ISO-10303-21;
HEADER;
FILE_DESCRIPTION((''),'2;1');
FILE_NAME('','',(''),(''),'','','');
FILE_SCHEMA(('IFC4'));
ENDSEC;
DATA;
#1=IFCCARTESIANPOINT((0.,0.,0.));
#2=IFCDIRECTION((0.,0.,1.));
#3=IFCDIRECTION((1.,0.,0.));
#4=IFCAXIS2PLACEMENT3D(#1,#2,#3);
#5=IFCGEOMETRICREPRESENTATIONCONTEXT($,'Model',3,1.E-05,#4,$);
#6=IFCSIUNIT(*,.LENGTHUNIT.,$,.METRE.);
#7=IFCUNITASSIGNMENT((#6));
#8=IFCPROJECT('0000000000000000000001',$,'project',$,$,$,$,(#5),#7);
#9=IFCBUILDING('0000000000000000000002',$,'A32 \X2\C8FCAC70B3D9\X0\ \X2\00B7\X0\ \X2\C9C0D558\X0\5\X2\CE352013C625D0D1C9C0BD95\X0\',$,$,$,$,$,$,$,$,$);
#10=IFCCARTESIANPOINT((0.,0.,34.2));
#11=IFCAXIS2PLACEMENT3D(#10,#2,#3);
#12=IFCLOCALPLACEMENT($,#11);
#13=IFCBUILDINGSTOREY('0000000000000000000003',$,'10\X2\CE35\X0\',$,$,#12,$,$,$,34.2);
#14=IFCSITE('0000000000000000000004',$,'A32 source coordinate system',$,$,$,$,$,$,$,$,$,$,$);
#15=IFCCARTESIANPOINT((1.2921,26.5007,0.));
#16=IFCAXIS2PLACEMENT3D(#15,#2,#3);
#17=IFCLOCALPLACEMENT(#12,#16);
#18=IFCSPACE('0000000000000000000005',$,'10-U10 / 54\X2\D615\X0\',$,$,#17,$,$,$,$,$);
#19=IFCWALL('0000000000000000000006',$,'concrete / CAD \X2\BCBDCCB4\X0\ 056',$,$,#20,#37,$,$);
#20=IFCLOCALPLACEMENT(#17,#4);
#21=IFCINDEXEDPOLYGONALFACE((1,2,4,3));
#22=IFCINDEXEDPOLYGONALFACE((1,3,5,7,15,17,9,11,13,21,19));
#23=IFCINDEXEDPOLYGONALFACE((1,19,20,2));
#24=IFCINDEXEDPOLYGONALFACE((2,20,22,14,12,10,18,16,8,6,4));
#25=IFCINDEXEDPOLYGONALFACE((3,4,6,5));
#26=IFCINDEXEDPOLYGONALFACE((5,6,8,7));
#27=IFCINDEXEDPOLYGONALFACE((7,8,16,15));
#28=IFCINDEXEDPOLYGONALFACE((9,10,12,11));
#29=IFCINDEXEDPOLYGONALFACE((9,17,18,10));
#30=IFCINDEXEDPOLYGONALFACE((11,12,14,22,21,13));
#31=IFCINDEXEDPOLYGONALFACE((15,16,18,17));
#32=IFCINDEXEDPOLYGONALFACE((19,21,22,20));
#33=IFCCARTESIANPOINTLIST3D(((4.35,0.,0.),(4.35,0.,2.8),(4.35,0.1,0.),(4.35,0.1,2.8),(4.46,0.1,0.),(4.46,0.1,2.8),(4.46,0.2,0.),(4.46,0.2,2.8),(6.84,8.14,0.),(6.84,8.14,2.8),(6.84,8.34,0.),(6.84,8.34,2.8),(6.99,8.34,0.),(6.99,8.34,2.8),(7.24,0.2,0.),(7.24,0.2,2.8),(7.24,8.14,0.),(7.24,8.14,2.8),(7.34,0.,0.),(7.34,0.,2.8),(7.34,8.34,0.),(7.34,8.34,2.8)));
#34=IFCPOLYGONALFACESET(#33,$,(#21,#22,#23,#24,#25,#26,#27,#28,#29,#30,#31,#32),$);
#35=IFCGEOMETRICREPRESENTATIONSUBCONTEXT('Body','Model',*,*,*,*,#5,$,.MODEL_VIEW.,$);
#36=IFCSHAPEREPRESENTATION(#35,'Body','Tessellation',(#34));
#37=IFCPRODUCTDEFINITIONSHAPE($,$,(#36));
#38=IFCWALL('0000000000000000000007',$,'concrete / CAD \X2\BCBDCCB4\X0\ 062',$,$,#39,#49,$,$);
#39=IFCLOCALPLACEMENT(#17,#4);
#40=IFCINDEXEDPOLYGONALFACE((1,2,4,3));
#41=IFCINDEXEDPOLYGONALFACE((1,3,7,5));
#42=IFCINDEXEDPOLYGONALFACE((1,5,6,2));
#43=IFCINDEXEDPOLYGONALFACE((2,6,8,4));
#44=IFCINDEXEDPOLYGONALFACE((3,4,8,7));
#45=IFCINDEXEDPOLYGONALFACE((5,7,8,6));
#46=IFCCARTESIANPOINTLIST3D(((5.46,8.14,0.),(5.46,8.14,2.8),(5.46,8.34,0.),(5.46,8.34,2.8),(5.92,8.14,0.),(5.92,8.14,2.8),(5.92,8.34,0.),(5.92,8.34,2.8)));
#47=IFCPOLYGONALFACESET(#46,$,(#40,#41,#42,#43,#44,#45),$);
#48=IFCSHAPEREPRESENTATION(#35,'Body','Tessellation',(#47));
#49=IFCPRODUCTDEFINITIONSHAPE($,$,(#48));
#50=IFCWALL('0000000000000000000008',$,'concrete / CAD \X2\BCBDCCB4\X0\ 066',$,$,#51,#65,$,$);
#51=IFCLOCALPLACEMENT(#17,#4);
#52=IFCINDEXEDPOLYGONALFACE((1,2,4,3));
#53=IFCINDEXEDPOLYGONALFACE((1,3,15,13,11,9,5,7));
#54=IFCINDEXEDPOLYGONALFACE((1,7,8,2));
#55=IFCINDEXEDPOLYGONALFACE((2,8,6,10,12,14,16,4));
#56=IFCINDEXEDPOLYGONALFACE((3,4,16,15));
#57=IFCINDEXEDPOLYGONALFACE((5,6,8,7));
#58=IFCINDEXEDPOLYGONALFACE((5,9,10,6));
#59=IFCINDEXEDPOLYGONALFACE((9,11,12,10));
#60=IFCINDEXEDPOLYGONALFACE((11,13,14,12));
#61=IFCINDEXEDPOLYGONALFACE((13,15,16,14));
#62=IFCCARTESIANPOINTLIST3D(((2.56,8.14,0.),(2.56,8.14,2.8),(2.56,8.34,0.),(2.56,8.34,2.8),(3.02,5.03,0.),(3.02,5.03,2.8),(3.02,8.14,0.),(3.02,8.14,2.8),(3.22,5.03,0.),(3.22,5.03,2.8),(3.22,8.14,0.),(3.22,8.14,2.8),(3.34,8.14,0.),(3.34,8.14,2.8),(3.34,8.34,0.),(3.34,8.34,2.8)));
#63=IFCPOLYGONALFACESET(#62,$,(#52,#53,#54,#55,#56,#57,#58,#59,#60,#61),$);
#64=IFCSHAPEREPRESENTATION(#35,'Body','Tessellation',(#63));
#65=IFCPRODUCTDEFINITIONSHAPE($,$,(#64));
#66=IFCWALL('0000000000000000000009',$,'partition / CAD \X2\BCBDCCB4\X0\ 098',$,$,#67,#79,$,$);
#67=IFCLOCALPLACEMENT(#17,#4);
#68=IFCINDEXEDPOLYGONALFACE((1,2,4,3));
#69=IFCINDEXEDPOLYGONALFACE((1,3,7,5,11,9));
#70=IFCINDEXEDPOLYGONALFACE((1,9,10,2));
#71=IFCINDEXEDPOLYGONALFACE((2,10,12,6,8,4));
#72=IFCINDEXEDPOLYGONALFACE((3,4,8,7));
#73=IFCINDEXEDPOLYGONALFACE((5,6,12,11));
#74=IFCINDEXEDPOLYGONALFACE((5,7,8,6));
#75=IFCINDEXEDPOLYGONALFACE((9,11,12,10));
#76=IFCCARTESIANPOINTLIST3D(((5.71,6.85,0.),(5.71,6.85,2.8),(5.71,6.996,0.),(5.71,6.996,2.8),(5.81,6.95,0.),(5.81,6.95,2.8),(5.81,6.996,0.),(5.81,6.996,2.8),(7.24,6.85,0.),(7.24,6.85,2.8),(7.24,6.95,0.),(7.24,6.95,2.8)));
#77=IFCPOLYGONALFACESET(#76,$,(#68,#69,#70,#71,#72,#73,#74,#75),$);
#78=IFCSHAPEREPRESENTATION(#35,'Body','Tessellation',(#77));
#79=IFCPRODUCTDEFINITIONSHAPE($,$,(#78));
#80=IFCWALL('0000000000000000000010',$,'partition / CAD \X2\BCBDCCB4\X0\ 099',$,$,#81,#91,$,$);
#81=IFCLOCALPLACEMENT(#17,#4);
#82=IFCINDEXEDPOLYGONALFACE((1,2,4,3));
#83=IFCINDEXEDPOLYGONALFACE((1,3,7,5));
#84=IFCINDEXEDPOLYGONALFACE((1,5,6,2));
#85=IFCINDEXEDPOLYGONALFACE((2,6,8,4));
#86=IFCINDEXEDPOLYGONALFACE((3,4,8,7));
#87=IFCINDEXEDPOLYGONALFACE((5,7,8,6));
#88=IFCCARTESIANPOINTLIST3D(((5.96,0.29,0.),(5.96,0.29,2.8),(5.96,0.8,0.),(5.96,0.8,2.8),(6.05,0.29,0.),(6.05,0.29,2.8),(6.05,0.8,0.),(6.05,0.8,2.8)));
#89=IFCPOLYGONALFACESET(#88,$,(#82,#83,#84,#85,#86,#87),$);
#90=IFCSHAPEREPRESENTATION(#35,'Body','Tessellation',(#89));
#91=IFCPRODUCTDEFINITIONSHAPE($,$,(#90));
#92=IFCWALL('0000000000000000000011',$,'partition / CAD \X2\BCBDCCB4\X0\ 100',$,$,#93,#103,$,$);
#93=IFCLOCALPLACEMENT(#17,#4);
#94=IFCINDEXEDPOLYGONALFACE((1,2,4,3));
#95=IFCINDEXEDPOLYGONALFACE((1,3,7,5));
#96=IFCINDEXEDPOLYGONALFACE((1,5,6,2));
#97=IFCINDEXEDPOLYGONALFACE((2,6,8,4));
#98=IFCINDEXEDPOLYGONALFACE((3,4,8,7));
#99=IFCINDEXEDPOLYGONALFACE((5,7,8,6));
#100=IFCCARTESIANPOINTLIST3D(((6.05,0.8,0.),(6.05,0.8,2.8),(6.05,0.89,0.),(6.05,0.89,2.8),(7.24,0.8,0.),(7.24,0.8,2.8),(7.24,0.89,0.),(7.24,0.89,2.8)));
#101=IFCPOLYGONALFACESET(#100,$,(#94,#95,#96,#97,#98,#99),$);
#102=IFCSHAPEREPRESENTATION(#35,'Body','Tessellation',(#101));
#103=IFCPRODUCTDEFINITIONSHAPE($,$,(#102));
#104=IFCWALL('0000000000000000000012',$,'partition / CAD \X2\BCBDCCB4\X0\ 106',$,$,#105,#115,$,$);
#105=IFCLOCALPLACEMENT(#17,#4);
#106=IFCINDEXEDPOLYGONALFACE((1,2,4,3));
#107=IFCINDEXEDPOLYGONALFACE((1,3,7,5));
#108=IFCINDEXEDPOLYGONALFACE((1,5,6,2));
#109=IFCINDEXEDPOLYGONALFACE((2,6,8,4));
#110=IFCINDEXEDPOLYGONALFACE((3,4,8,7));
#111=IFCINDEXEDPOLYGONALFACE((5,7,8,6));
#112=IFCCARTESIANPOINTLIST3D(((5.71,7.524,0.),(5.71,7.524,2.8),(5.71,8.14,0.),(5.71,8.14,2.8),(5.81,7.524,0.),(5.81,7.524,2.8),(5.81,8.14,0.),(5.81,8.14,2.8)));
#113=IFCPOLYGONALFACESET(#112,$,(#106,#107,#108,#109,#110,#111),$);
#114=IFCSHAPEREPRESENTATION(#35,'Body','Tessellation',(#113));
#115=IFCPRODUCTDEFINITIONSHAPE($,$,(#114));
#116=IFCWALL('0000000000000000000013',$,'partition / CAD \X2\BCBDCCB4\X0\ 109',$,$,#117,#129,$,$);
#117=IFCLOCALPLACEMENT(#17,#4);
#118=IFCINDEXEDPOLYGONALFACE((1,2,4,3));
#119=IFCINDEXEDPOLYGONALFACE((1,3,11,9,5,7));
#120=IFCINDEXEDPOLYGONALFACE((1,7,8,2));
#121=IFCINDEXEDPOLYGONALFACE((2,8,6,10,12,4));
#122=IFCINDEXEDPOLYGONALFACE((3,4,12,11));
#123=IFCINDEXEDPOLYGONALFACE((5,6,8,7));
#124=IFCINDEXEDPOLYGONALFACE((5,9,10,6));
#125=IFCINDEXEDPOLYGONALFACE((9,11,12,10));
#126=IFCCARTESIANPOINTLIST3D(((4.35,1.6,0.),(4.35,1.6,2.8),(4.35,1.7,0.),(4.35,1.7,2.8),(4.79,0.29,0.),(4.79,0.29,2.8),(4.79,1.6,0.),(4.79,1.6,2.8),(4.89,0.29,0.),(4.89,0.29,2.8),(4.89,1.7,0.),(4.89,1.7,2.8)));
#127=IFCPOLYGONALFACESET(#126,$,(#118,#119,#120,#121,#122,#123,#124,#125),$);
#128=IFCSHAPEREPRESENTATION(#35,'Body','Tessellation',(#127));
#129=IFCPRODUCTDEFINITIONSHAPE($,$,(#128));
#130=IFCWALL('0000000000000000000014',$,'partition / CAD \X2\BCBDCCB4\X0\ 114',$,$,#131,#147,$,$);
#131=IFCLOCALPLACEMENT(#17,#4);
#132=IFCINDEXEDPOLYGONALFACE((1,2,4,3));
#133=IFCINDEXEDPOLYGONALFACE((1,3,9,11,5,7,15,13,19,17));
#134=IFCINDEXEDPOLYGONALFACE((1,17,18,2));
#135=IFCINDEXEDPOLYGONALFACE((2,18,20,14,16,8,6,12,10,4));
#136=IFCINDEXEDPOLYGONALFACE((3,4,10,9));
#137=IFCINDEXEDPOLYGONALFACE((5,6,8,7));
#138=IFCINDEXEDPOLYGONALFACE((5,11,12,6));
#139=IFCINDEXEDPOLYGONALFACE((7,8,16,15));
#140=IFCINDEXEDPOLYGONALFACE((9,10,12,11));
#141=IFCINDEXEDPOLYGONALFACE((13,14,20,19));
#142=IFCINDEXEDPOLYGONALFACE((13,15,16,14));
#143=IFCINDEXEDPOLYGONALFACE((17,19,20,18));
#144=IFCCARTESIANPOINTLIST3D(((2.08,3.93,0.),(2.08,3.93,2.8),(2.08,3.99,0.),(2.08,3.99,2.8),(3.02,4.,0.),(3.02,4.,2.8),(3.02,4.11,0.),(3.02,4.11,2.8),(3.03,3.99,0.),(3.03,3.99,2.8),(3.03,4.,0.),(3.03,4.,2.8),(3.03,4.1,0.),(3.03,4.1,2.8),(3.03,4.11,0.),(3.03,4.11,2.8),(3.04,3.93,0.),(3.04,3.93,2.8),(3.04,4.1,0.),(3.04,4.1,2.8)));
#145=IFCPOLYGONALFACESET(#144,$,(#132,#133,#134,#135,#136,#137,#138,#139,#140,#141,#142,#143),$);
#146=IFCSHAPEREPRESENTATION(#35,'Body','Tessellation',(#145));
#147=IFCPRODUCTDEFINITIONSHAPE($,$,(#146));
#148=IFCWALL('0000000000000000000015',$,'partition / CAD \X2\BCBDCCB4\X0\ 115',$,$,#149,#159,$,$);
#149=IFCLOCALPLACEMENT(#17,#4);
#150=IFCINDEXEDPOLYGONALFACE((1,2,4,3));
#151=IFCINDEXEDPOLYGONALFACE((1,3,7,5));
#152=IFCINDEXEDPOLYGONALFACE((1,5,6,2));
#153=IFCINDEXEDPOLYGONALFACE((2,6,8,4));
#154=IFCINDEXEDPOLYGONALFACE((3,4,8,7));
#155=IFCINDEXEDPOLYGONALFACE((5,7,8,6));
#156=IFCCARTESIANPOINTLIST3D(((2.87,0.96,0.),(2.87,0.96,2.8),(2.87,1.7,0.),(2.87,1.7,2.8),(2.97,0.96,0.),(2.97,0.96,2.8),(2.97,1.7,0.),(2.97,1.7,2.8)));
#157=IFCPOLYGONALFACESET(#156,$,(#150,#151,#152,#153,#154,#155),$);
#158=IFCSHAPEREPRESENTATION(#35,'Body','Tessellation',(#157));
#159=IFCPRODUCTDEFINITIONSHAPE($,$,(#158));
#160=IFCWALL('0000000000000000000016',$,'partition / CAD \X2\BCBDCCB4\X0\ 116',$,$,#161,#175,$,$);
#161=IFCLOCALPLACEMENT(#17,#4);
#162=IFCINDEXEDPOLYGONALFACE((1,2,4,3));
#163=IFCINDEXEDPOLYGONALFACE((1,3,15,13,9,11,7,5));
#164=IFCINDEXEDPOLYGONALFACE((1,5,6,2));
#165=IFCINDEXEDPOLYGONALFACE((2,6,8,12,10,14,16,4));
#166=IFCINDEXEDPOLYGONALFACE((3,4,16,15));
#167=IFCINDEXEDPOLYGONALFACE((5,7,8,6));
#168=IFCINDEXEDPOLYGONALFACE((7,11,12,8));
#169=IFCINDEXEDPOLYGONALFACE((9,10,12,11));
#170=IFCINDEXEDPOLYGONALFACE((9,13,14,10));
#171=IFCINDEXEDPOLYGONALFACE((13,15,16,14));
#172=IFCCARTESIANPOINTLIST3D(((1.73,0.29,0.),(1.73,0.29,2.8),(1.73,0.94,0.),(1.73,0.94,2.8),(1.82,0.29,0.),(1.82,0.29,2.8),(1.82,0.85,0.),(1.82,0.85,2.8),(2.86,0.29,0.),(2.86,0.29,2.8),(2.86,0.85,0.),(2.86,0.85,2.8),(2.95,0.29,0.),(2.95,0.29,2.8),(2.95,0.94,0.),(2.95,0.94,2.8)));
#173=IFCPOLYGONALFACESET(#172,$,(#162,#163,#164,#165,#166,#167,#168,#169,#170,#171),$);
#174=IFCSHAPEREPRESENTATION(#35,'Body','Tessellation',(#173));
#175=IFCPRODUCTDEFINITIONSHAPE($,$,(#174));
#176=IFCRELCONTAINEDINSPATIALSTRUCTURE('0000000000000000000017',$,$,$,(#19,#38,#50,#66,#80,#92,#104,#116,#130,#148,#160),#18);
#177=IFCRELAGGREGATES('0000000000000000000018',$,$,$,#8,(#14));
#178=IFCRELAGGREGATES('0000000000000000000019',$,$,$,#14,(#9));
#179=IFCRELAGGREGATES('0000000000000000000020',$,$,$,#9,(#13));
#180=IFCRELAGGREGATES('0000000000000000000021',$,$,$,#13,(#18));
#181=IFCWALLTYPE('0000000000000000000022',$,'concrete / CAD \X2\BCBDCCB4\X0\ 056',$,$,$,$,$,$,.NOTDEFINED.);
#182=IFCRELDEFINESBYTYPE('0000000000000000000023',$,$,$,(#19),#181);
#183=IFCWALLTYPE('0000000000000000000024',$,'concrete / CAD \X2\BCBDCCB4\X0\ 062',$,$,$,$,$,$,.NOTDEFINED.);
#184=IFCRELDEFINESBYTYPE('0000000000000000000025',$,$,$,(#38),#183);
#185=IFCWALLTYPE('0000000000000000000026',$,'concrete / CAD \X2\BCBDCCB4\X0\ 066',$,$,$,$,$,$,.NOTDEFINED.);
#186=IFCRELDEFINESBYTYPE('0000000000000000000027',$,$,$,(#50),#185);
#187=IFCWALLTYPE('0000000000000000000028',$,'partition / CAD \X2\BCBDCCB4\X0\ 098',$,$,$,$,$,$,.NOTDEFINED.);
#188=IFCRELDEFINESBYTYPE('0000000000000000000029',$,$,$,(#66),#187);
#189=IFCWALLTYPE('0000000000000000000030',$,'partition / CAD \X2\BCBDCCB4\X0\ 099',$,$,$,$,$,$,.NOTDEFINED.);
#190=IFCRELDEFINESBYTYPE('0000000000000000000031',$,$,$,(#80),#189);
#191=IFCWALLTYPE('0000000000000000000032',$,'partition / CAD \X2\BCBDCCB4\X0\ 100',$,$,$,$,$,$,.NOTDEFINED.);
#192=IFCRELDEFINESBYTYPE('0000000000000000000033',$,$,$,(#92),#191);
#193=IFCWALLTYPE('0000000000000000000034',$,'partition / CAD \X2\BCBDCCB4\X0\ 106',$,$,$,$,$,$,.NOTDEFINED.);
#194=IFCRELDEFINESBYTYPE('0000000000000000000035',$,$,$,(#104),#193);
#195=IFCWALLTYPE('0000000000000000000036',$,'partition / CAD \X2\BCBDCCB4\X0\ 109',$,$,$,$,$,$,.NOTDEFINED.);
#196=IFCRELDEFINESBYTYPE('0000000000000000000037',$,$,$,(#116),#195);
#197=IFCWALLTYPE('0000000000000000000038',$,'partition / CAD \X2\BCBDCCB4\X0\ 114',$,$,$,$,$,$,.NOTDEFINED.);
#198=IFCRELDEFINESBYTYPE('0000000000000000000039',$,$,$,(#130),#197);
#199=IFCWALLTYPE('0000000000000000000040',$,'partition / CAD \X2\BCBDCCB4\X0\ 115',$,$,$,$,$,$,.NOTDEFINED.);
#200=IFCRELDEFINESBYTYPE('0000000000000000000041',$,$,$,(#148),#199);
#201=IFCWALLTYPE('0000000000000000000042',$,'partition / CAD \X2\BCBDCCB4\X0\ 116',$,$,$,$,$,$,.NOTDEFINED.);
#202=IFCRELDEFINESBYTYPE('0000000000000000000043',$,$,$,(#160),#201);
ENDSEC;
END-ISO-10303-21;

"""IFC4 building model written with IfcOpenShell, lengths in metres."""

from ifc_helpers import new_model, si_unit, frame, origin, origin_with_axes, place, context, subcontext, project, spatial, polyline, outline, extrude, source, transform, mapped, type_object, type_shapes, element, save


model = new_model("IFC4")

# Units and contexts
model_context = context("Model", 3, precision=1e-05, world=origin_with_axes())
body_context = subcontext(model_context, "Body", "Model", "MODEL_VIEW")
ifc_project = project(units=[si_unit("LENGTHUNIT", "METRE")], contexts=[model_context])

# Site, building, storey, space
site = spatial("IfcSite", under=ifc_project, Name="A32 source coordinate system")
building = spatial("IfcBuilding", under=site, Name="A32 주거동 · 지하5층–옥탑지붕")
storey_placement = place(None, frame((0.0, 0.0, 34.2), z_axis=(0.0, 0.0, 1.0), x_axis=(1.0, 0.0, 0.0)))
storey = spatial("IfcBuildingStorey", under=building, at=storey_placement, Name="10층", Elevation=34.2)
space_placement = place(storey_placement, frame((1.2921, 26.5007, 0.0), z_axis=(0.0, 0.0, 1.0), x_axis=(1.0, 0.0, 0.0)))
space = spatial("IfcSpace", under=storey, at=space_placement, Name="10-U10 / 54형")

# Walls
wall_type_1 = type_object("IfcWallType", Name="concrete / CAD 벽체 056", PredefinedType="NOTDEFINED")
shared_shape_1 = source(origin(), body_context, "Body", "SweptSolid", [
    extrude(outline(polyline([(7.24, 0.2), (7.24, 8.14), (6.84, 8.14), (6.84, 8.34), (6.99, 8.34), (6.99, 8.34), (7.34, 8.34), (7.34, 0.0), (4.35, 0.0), (4.35, 0.1), (4.46, 0.1), (4.46, 0.2), (7.24, 0.2)])), origin(), (0.0, 0.0, 1.0), 2.8),
])
type_shapes(wall_type_1, [shared_shape_1])
wall_1_placement = place(space_placement, origin_with_axes())
element("IfcWall", 1, at=wall_1_placement, inside=space, type_object=wall_type_1, Name="concrete / CAD 벽체 056", context=body_context, shape_type="MappedRepresentation", body=[
    mapped(shared_shape_1, transform((0.0, 0.0, 0.0), scale=1.0)),
])
wall_type_2 = type_object("IfcWallType", Name="concrete / CAD 벽체 062", PredefinedType="NOTDEFINED")
shared_shape_2 = source(origin(), body_context, "Body", "SweptSolid", [
    extrude(outline(polyline([(5.46, 8.14), (5.46, 8.34), (5.92, 8.34), (5.92, 8.14), (5.46, 8.14)])), origin(), (0.0, 0.0, 1.0), 2.8),
])
type_shapes(wall_type_2, [shared_shape_2])
wall_2_placement = place(space_placement, origin_with_axes())
element("IfcWall", 2, at=wall_2_placement, inside=space, type_object=wall_type_2, Name="concrete / CAD 벽체 062", context=body_context, shape_type="MappedRepresentation", body=[
    mapped(shared_shape_2, transform((0.0, 0.0, 0.0), scale=1.0)),
])
wall_type_3 = type_object("IfcWallType", Name="concrete / CAD 벽체 066", PredefinedType="NOTDEFINED")
shared_shape_3 = source(origin(), body_context, "Body", "SweptSolid", [
    extrude(outline(polyline([(3.22, 8.14), (3.22, 5.03), (3.02, 5.03), (3.02, 8.14), (2.56, 8.14), (2.56, 8.34), (3.34, 8.34), (3.34, 8.14), (3.22, 8.14)])), origin(), (0.0, 0.0, 1.0), 2.8),
])
type_shapes(wall_type_3, [shared_shape_3])
wall_3_placement = place(space_placement, origin_with_axes())
element("IfcWall", 3, at=wall_3_placement, inside=space, type_object=wall_type_3, Name="concrete / CAD 벽체 066", context=body_context, shape_type="MappedRepresentation", body=[
    mapped(shared_shape_3, transform((0.0, 0.0, 0.0), scale=1.0)),
])
wall_type_4 = type_object("IfcWallType", Name="partition / CAD 벽체 098", PredefinedType="NOTDEFINED")
shared_shape_4 = source(origin(), body_context, "Body", "SweptSolid", [
    extrude(outline(polyline([(5.71, 6.996), (5.81, 6.996), (5.81, 6.95), (7.24, 6.95), (7.24, 6.85), (5.71, 6.85), (5.71, 6.996)])), origin(), (0.0, 0.0, 1.0), 2.8),
])
type_shapes(wall_type_4, [shared_shape_4])
wall_4_placement = place(space_placement, origin_with_axes())
element("IfcWall", 4, at=wall_4_placement, inside=space, type_object=wall_type_4, Name="partition / CAD 벽체 098", context=body_context, shape_type="MappedRepresentation", body=[
    mapped(shared_shape_4, transform((0.0, 0.0, 0.0), scale=1.0)),
])
wall_type_5 = type_object("IfcWallType", Name="partition / CAD 벽체 099", PredefinedType="NOTDEFINED")
shared_shape_5 = source(origin(), body_context, "Body", "SweptSolid", [
    extrude(outline(polyline([(6.05, 0.8), (6.05, 0.29), (5.96, 0.29), (5.96, 0.8), (6.05, 0.8)])), origin(), (0.0, 0.0, 1.0), 2.8),
])
type_shapes(wall_type_5, [shared_shape_5])
wall_5_placement = place(space_placement, origin_with_axes())
element("IfcWall", 5, at=wall_5_placement, inside=space, type_object=wall_type_5, Name="partition / CAD 벽체 099", context=body_context, shape_type="MappedRepresentation", body=[
    mapped(shared_shape_5, transform((0.0, 0.0, 0.0), scale=1.0)),
])
wall_type_6 = type_object("IfcWallType", Name="partition / CAD 벽체 100", PredefinedType="NOTDEFINED")
shared_shape_6 = source(origin(), body_context, "Body", "SweptSolid", [
    extrude(outline(polyline([(7.24, 0.8), (6.05, 0.8), (6.05, 0.89), (7.24, 0.89), (7.24, 0.8)])), origin(), (0.0, 0.0, 1.0), 2.8),
])
type_shapes(wall_type_6, [shared_shape_6])
wall_6_placement = place(space_placement, origin_with_axes())
element("IfcWall", 6, at=wall_6_placement, inside=space, type_object=wall_type_6, Name="partition / CAD 벽체 100", context=body_context, shape_type="MappedRepresentation", body=[
    mapped(shared_shape_6, transform((0.0, 0.0, 0.0), scale=1.0)),
])
wall_type_7 = type_object("IfcWallType", Name="partition / CAD 벽체 106", PredefinedType="NOTDEFINED")
shared_shape_7 = source(origin(), body_context, "Body", "SweptSolid", [
    extrude(outline(polyline([(5.71, 8.14), (5.81, 8.14), (5.81, 7.524), (5.71, 7.524), (5.71, 8.14)])), origin(), (0.0, 0.0, 1.0), 2.8),
])
type_shapes(wall_type_7, [shared_shape_7])
wall_7_placement = place(space_placement, origin_with_axes())
element("IfcWall", 7, at=wall_7_placement, inside=space, type_object=wall_type_7, Name="partition / CAD 벽체 106", context=body_context, shape_type="MappedRepresentation", body=[
    mapped(shared_shape_7, transform((0.0, 0.0, 0.0), scale=1.0)),
])
wall_type_8 = type_object("IfcWallType", Name="partition / CAD 벽체 109", PredefinedType="NOTDEFINED")
shared_shape_8 = source(origin(), body_context, "Body", "SweptSolid", [
    extrude(outline(polyline([(4.79, 1.6), (4.35, 1.6), (4.35, 1.7), (4.89, 1.7), (4.89, 0.29), (4.79, 0.29), (4.79, 1.6)])), origin(), (0.0, 0.0, 1.0), 2.8),
])
type_shapes(wall_type_8, [shared_shape_8])
wall_8_placement = place(space_placement, origin_with_axes())
element("IfcWall", 8, at=wall_8_placement, inside=space, type_object=wall_type_8, Name="partition / CAD 벽체 109", context=body_context, shape_type="MappedRepresentation", body=[
    mapped(shared_shape_8, transform((0.0, 0.0, 0.0), scale=1.0)),
])
wall_type_9 = type_object("IfcWallType", Name="partition / CAD 벽체 114", PredefinedType="NOTDEFINED")
shared_shape_9 = source(origin(), body_context, "Body", "SweptSolid", [
    extrude(outline(polyline([(2.08, 3.99), (3.03, 3.99), (3.03, 4.0), (3.02, 4.0), (3.02, 4.11), (3.03, 4.11), (3.03, 4.1), (3.04, 4.1), (3.04, 3.93), (2.08, 3.93), (2.08, 3.99)])), origin(), (0.0, 0.0, 1.0), 2.8),
])
type_shapes(wall_type_9, [shared_shape_9])
wall_9_placement = place(space_placement, origin_with_axes())
element("IfcWall", 9, at=wall_9_placement, inside=space, type_object=wall_type_9, Name="partition / CAD 벽체 114", context=body_context, shape_type="MappedRepresentation", body=[
    mapped(shared_shape_9, transform((0.0, 0.0, 0.0), scale=1.0)),
])
wall_type_10 = type_object("IfcWallType", Name="partition / CAD 벽체 115", PredefinedType="NOTDEFINED")
shared_shape_10 = source(origin(), body_context, "Body", "SweptSolid", [
    extrude(outline(polyline([(2.87, 1.7), (2.97, 1.7), (2.97, 0.96), (2.87, 0.96), (2.87, 1.7)])), origin(), (0.0, 0.0, 1.0), 2.8),
])
type_shapes(wall_type_10, [shared_shape_10])
wall_10_placement = place(space_placement, origin_with_axes())
element("IfcWall", 10, at=wall_10_placement, inside=space, type_object=wall_type_10, Name="partition / CAD 벽체 115", context=body_context, shape_type="MappedRepresentation", body=[
    mapped(shared_shape_10, transform((0.0, 0.0, 0.0), scale=1.0)),
])
wall_type_11 = type_object("IfcWallType", Name="partition / CAD 벽체 116", PredefinedType="NOTDEFINED")
shared_shape_11 = source(origin(), body_context, "Body", "SweptSolid", [
    extrude(outline(polyline([(2.95, 0.29), (2.86, 0.29), (2.86, 0.85), (1.82, 0.85), (1.82, 0.29), (1.73, 0.29), (1.73, 0.94), (2.95, 0.94), (2.95, 0.29)])), origin(), (0.0, 0.0, 1.0), 2.8),
])
type_shapes(wall_type_11, [shared_shape_11])
wall_11_placement = place(space_placement, origin_with_axes())
element("IfcWall", 11, at=wall_11_placement, inside=space, type_object=wall_type_11, Name="partition / CAD 벽체 116", context=body_context, shape_type="MappedRepresentation", body=[
    mapped(shared_shape_11, transform((0.0, 0.0, 0.0), scale=1.0)),
])

save(model, "model.ifc")
